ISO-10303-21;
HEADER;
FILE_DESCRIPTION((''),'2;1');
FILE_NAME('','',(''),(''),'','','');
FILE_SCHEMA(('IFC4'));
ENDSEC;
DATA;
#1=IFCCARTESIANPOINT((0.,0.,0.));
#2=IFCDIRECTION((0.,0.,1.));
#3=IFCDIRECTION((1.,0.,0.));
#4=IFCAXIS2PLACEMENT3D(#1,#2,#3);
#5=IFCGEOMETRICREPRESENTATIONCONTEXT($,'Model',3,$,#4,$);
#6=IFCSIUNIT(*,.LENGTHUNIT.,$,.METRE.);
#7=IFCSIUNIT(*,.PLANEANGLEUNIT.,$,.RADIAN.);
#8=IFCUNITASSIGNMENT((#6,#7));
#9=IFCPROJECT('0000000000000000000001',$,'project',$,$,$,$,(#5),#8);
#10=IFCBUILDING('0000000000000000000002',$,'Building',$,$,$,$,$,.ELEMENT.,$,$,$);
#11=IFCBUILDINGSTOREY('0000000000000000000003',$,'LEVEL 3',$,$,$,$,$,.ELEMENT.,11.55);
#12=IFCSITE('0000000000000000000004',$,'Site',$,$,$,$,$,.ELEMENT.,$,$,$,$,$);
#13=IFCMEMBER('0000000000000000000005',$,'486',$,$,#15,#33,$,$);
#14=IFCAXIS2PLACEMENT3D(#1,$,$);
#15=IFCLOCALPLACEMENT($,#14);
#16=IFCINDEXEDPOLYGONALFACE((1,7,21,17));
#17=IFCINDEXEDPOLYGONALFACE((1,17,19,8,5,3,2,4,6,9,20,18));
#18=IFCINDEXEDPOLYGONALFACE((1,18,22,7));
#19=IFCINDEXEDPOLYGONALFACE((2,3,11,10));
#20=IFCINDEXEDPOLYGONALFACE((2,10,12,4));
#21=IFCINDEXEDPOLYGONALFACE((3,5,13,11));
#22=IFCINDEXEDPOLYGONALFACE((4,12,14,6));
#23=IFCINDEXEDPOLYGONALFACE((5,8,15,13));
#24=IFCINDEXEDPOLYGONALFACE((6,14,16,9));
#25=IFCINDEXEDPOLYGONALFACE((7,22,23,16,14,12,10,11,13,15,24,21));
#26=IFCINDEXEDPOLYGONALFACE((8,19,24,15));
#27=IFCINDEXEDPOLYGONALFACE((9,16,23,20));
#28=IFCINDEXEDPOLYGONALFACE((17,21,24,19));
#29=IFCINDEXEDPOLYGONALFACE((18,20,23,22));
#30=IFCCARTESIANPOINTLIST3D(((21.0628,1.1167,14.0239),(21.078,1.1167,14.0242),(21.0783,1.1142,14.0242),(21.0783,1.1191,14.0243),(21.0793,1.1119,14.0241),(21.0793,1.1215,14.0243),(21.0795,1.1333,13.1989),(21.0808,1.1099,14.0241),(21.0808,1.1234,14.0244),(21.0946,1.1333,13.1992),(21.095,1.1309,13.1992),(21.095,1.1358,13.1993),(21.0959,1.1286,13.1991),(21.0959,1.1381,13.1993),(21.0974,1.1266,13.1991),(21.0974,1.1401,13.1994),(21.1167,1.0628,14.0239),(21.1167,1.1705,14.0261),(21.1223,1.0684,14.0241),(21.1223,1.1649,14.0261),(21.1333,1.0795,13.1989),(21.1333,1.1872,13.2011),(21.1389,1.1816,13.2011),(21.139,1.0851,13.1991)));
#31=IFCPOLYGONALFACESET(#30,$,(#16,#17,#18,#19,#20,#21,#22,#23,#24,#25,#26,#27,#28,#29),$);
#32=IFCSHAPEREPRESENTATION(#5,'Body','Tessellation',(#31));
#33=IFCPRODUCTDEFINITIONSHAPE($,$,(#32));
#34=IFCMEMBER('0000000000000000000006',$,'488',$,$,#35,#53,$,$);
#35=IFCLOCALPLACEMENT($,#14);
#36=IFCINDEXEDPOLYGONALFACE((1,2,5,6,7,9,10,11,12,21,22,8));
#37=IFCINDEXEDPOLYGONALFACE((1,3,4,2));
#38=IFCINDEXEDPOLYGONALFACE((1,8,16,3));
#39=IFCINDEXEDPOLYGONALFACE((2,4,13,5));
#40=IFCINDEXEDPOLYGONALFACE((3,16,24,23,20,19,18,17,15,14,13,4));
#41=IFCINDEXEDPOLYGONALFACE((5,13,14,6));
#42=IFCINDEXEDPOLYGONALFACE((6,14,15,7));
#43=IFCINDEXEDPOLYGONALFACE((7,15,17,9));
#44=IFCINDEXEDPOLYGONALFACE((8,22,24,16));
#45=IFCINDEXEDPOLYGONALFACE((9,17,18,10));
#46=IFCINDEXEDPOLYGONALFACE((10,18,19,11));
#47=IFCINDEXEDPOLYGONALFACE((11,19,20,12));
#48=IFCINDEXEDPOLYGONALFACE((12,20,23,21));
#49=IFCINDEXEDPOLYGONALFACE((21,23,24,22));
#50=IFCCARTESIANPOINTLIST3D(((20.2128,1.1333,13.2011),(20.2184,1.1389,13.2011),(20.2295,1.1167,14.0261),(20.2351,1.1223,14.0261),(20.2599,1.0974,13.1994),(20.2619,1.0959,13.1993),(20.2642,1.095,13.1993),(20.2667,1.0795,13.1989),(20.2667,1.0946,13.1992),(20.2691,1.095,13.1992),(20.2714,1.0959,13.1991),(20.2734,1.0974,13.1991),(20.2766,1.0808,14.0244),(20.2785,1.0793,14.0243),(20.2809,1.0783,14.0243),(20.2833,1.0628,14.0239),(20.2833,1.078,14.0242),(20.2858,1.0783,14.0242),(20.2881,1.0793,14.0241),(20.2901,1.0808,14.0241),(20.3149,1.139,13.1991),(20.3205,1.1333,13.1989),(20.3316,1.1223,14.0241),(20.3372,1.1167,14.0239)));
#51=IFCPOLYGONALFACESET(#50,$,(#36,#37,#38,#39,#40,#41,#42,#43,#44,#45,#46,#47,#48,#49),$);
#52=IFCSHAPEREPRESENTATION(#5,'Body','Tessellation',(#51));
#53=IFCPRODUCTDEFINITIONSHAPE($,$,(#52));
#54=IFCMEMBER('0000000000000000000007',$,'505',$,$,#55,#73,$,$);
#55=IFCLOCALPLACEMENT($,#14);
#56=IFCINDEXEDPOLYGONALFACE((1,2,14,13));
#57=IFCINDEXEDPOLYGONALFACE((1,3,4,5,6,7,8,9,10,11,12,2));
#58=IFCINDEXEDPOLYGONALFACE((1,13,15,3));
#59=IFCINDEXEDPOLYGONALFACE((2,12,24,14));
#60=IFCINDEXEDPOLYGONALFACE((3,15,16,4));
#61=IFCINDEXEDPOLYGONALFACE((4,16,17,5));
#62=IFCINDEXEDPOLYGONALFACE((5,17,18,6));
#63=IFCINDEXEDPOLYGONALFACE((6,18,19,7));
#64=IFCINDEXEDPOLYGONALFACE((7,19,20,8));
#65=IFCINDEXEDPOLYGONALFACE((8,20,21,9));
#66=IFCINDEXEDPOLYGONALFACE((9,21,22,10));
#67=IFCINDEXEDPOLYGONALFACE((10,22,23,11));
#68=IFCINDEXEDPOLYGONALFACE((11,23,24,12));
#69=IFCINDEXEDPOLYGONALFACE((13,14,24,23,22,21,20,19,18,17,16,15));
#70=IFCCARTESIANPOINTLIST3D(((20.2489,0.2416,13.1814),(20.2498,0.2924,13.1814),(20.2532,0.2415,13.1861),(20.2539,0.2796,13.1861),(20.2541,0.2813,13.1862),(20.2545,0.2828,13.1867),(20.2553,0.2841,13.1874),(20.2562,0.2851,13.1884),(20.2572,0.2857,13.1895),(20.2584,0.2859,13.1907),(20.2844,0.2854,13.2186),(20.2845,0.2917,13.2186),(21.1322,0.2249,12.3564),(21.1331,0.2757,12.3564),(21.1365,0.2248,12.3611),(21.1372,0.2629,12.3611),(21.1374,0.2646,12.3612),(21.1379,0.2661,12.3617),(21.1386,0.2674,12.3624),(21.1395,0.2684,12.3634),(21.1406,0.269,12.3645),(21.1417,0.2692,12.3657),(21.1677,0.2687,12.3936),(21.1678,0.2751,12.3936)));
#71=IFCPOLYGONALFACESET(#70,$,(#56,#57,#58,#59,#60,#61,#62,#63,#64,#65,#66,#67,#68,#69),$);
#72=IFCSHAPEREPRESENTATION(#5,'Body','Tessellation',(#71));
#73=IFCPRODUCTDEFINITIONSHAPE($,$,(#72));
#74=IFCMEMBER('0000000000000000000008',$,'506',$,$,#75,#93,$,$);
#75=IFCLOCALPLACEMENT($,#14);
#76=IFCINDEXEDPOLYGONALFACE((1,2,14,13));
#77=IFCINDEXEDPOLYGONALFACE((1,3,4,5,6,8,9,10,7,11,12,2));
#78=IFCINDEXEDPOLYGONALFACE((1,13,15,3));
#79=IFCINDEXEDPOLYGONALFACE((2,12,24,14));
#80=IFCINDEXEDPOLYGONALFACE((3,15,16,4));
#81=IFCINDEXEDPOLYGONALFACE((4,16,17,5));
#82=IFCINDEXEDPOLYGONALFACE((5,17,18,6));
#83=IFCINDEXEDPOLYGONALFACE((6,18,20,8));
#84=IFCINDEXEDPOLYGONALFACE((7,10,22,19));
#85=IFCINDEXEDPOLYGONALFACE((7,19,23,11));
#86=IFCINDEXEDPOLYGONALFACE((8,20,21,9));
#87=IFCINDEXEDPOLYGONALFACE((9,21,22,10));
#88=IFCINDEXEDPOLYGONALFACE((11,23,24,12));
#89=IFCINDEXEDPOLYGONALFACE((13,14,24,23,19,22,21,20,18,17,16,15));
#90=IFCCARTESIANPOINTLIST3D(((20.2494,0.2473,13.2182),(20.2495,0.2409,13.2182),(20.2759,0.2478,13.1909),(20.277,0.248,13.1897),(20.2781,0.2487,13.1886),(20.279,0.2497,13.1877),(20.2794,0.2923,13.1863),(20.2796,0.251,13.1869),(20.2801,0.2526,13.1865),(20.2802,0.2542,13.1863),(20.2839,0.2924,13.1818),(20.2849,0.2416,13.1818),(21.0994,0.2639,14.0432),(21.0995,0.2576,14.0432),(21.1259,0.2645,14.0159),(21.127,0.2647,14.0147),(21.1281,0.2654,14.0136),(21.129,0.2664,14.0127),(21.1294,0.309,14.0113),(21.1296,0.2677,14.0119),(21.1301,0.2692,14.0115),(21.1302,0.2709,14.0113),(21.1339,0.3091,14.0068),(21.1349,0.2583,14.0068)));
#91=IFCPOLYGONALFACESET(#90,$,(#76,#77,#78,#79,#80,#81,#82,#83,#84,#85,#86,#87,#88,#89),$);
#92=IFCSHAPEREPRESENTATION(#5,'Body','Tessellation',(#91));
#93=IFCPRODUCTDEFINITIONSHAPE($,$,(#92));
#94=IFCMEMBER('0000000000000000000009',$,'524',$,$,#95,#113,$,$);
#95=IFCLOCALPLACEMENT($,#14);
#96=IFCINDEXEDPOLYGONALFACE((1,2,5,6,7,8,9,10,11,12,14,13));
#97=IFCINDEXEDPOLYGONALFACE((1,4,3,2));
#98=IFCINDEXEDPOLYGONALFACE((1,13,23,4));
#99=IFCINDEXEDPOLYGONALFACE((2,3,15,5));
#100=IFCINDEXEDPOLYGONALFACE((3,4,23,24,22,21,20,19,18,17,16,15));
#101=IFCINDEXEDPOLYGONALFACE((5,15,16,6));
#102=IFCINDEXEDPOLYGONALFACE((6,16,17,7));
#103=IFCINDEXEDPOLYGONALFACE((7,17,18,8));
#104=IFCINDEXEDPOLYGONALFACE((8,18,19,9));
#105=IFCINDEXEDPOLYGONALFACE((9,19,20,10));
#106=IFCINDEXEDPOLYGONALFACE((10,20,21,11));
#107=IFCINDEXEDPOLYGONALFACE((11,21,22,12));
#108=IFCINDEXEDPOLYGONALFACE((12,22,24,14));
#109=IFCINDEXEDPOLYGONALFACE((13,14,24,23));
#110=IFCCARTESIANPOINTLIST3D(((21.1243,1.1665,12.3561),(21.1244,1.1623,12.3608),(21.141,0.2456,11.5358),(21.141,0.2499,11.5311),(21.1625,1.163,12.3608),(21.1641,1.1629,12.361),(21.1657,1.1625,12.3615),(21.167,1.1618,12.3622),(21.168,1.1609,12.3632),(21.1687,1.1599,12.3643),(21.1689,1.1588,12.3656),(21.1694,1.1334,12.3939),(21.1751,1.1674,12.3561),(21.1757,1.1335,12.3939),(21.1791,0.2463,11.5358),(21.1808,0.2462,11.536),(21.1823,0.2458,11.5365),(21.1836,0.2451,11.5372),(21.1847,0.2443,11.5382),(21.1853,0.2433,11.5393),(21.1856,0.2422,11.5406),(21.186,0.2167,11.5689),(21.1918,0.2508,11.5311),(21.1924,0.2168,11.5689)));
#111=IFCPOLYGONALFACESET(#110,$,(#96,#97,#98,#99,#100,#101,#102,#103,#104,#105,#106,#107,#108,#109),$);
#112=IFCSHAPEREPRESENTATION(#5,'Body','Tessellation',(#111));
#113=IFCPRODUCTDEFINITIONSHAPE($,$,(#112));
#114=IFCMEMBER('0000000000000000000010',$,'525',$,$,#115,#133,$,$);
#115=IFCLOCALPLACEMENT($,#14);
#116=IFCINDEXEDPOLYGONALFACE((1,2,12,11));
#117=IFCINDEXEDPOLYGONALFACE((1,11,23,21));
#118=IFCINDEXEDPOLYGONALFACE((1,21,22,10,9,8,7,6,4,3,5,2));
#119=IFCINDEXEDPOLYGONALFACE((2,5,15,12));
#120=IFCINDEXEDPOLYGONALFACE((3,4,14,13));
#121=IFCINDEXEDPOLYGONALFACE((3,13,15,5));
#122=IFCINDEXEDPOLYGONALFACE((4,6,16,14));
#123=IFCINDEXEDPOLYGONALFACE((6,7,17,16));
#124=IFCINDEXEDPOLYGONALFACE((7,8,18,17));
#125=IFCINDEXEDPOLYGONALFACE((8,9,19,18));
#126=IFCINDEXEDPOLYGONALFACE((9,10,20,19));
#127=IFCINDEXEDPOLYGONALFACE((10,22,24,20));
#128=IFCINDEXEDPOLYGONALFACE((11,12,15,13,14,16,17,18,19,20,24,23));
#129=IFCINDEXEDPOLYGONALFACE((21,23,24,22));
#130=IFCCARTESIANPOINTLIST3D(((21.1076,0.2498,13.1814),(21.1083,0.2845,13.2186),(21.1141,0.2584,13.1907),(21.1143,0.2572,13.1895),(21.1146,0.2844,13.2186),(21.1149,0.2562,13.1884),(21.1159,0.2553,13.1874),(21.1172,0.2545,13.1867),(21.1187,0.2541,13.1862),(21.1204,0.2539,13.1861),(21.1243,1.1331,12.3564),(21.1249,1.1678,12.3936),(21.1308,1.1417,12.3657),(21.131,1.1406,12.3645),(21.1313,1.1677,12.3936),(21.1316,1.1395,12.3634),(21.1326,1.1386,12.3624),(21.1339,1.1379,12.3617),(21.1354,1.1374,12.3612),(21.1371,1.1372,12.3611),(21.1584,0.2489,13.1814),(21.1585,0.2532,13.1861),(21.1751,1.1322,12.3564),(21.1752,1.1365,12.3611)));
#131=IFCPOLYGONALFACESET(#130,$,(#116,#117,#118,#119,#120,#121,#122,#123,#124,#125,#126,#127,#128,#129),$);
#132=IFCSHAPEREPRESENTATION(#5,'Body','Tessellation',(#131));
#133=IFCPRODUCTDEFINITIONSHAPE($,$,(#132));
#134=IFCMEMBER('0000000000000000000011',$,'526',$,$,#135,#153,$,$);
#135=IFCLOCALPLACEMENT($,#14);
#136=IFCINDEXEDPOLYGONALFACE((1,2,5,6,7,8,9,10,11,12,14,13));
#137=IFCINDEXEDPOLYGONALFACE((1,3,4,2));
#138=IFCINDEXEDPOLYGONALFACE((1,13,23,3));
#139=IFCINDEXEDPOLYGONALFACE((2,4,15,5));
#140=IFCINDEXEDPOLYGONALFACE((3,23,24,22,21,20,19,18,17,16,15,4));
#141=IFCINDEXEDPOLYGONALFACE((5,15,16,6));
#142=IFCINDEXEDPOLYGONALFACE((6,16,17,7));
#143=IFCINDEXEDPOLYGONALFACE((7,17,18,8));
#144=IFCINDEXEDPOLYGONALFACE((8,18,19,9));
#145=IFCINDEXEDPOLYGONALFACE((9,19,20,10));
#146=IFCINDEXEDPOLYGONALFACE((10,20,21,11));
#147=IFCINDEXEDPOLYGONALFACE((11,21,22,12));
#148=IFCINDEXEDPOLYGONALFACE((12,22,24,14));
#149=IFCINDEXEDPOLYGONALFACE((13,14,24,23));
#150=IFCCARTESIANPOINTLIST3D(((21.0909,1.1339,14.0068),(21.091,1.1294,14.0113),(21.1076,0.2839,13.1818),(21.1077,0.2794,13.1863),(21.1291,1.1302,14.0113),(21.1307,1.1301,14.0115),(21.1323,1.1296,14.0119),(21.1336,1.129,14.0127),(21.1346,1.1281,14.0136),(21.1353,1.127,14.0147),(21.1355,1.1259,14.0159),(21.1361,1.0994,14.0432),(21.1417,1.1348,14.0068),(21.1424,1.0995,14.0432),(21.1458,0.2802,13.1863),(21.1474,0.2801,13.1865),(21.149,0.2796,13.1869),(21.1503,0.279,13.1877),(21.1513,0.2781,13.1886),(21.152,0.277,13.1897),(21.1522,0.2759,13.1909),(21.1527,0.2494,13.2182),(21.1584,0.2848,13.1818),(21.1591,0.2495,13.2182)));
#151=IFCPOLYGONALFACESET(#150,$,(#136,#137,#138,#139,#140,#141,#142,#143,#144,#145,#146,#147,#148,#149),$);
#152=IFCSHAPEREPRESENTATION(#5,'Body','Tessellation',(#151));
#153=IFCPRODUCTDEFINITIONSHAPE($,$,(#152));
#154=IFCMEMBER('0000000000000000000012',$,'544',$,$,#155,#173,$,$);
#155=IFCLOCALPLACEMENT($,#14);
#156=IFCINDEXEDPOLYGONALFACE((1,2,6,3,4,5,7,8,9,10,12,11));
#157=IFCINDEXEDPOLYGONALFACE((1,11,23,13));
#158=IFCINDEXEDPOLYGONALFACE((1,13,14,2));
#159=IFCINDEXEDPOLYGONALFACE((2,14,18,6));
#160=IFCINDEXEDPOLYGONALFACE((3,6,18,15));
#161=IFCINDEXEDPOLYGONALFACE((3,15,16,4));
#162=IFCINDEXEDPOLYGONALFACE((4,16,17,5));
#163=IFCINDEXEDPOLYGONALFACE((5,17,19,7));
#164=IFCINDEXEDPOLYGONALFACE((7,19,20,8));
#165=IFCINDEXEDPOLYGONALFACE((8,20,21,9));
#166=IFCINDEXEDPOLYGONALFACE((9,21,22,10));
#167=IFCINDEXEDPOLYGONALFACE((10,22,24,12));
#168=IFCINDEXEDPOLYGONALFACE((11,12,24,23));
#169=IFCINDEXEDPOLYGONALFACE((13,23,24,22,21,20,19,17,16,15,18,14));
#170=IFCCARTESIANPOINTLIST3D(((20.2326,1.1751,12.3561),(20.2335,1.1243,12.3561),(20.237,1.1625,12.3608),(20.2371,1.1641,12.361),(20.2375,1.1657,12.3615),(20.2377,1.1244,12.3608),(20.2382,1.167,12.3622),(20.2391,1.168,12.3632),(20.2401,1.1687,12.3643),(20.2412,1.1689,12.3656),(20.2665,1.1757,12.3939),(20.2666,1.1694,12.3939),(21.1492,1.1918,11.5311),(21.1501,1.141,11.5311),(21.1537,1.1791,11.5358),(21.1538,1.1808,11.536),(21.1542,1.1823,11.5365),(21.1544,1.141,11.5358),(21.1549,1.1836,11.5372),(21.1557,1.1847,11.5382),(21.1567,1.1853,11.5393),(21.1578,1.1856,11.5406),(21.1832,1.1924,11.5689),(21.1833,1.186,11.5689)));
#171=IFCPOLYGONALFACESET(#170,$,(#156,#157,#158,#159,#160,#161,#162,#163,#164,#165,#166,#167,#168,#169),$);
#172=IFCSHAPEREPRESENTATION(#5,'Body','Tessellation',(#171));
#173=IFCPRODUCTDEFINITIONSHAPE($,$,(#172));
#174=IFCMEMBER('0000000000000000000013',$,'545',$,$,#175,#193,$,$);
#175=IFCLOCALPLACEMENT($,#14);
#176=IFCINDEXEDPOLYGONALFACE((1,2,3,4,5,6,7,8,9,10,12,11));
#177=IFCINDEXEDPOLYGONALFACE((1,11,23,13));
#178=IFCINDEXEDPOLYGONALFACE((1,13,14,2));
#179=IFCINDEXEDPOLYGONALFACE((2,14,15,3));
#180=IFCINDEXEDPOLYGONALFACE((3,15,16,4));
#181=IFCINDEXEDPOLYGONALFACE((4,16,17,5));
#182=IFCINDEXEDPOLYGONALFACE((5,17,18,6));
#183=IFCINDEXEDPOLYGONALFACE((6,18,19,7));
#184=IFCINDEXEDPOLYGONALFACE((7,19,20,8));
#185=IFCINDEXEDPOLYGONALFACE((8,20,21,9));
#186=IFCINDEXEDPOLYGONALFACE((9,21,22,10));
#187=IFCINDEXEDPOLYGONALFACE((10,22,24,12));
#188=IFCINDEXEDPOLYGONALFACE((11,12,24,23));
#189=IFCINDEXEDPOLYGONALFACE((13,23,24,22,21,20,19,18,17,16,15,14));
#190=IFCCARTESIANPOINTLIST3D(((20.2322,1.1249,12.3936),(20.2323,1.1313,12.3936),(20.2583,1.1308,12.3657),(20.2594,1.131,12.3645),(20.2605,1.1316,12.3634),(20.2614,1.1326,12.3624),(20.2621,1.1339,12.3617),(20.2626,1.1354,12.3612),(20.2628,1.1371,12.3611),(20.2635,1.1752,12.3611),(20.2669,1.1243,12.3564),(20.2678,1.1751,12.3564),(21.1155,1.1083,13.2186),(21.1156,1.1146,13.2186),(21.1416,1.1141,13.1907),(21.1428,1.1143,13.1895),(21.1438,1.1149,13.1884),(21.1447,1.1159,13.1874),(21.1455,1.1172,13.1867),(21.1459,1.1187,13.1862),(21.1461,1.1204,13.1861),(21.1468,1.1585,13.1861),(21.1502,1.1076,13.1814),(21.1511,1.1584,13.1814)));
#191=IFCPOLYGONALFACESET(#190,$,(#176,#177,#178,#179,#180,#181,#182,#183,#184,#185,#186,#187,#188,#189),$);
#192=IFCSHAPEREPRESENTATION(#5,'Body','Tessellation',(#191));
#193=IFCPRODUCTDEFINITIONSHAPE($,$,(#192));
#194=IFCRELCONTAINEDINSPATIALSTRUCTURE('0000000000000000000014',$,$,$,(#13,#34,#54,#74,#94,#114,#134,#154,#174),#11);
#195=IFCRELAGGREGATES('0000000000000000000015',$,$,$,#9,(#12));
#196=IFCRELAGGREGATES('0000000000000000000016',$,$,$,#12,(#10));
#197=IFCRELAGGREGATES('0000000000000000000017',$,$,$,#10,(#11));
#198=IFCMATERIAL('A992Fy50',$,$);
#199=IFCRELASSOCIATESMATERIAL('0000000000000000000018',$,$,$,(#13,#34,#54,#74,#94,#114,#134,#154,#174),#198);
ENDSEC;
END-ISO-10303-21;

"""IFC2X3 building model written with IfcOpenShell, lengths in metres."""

from ifc_helpers import new_model, si_unit, frame, origin_with_axes, origin_2d_with_axis, place, context, project, spatial, l_section, extrude, material, element, save


model = new_model("IFC2X3")

# Units and contexts
model_context = context("Model", 3, world=origin_with_axes())
ifc_project = project(units=[si_unit("LENGTHUNIT", "METRE"), si_unit("PLANEANGLEUNIT", "RADIAN")], contexts=[model_context])

# Site, building, storey
site = spatial("IfcSite", under=ifc_project, Name="Site", CompositionType="ELEMENT")
building = spatial("IfcBuilding", under=site, Name="Building", CompositionType="ELEMENT")
storey = spatial("IfcBuildingStorey", under=building, Name="LEVEL 3", CompositionType="ELEMENT", Elevation=11.55)

# Shared definitions
ifc_material = material(Name="A992Fy50")

# Members
for number, where, z_axis, x_axis, name in (
    (1, (21.1333, 1.1333, 13.2), (-0.020194, -0.020194, 0.999592), (0.707107, -0.707107, 0.0), "486"),
    (2, (20.2667, 1.1333, 13.2), (0.020194, -0.020194, 0.999592), (0.707107, 0.707107, 0.0), "488"),
):
    element("IfcMember", number, at=place(None, frame(where, z_axis=z_axis, x_axis=x_axis)), inside=storey, material=ifc_material, Name=name, context=model_context, shape_type="SweptSolid", body=[
        extrude(l_section(Depth=0.0762, Width=0.0762, Thickness=0.0079, FilletRadius=0.0096, at=origin_2d_with_axis()), origin_with_axes(), (0.0, 0.0, 1.0), 0.8253),
    ])
member_1_placement = place(None, frame((21.15, 0.25, 12.375), z_axis=(-0.730756, 0.013788, 0.682499), x_axis=(-0.018865, -0.999822, 0.0)))
element("IfcMember", 3, at=member_1_placement, inside=storey, material=ifc_material, Name="505", context=model_context, shape_type="SweptSolid", body=[
    extrude(l_section(Depth=0.0508, Width=0.0508, Thickness=0.0063, FilletRadius=0.0063, at=origin_2d_with_axis()), origin_with_axes(), (0.0, 0.0, 1.0), 1.2088),
])
member_2_placement = place(None, frame((20.2667, 0.2667, 13.2), z_axis=(0.71751, 0.014069, 0.696406), x_axis=(-0.019604, 0.999808, 0.0)))
element("IfcMember", 4, at=member_2_placement, inside=storey, material=ifc_material, Name="506", context=model_context, shape_type="SweptSolid", body=[
    extrude(l_section(Depth=0.0508, Width=0.0508, Thickness=0.0063, FilletRadius=0.0063, at=origin_2d_with_axis()), origin_with_axes(), (0.0, 0.0, 1.0), 1.1847),
])
member_3_placement = place(None, frame((21.1667, 0.2333, 11.55), z_axis=(-0.013513, 0.743226, 0.668904), x_axis=(-0.999835, -0.018179, 0.0)))
element("IfcMember", 5, at=member_3_placement, inside=storey, material=ifc_material, Name="524", context=model_context, shape_type="SweptSolid", body=[
    extrude(l_section(Depth=0.0508, Width=0.0508, Thickness=0.0063, FilletRadius=0.0063, at=origin_2d_with_axis()), origin_with_axes(), (0.0, 0.0, 1.0), 1.2334),
])
member_4_placement = place(None, frame((21.15, 1.15, 12.375), z_axis=(-0.013788, -0.730756, 0.682499), x_axis=(0.999822, -0.018865, 0.0)))
element("IfcMember", 6, at=member_4_placement, inside=storey, material=ifc_material, Name="525", context=model_context, shape_type="SweptSolid", body=[
    extrude(l_section(Depth=0.0508, Width=0.0508, Thickness=0.0063, FilletRadius=0.0063, at=origin_2d_with_axis()), origin_with_axes(), (0.0, 0.0, 1.0), 1.2088),
])
member_5_placement = place(None, frame((21.1333, 0.2667, 13.2), z_axis=(-0.014069, 0.71751, 0.696406), x_axis=(-0.999808, -0.019604, 0.0)))
element("IfcMember", 7, at=member_5_placement, inside=storey, material=ifc_material, Name="526", context=model_context, shape_type="SweptSolid", body=[
    extrude(l_section(Depth=0.0508, Width=0.0508, Thickness=0.0063, FilletRadius=0.0063, at=origin_2d_with_axis()), origin_with_axes(), (0.0, 0.0, 1.0), 1.1847),
])
member_6_placement = place(None, frame((21.1667, 1.1667, 11.55), z_axis=(-0.743226, -0.013513, 0.668904), x_axis=(0.018179, -0.999835, 0.0)))
element("IfcMember", 8, at=member_6_placement, inside=storey, material=ifc_material, Name="544", context=model_context, shape_type="SweptSolid", body=[
    extrude(l_section(Depth=0.0508, Width=0.0508, Thickness=0.0063, FilletRadius=0.0063, at=origin_2d_with_axis()), origin_with_axes(), (0.0, 0.0, 1.0), 1.2334),
])
member_7_placement = place(None, frame((20.25, 1.15, 12.375), z_axis=(0.730756, -0.013788, 0.682499), x_axis=(0.018865, 0.999822, 0.0)))
element("IfcMember", 9, at=member_7_placement, inside=storey, material=ifc_material, Name="545", context=model_context, shape_type="SweptSolid", body=[
    extrude(l_section(Depth=0.0508, Width=0.0508, Thickness=0.0063, FilletRadius=0.0063, at=origin_2d_with_axis()), origin_with_axes(), (0.0, 0.0, 1.0), 1.2088),
])

save(model, "model.ifc")
